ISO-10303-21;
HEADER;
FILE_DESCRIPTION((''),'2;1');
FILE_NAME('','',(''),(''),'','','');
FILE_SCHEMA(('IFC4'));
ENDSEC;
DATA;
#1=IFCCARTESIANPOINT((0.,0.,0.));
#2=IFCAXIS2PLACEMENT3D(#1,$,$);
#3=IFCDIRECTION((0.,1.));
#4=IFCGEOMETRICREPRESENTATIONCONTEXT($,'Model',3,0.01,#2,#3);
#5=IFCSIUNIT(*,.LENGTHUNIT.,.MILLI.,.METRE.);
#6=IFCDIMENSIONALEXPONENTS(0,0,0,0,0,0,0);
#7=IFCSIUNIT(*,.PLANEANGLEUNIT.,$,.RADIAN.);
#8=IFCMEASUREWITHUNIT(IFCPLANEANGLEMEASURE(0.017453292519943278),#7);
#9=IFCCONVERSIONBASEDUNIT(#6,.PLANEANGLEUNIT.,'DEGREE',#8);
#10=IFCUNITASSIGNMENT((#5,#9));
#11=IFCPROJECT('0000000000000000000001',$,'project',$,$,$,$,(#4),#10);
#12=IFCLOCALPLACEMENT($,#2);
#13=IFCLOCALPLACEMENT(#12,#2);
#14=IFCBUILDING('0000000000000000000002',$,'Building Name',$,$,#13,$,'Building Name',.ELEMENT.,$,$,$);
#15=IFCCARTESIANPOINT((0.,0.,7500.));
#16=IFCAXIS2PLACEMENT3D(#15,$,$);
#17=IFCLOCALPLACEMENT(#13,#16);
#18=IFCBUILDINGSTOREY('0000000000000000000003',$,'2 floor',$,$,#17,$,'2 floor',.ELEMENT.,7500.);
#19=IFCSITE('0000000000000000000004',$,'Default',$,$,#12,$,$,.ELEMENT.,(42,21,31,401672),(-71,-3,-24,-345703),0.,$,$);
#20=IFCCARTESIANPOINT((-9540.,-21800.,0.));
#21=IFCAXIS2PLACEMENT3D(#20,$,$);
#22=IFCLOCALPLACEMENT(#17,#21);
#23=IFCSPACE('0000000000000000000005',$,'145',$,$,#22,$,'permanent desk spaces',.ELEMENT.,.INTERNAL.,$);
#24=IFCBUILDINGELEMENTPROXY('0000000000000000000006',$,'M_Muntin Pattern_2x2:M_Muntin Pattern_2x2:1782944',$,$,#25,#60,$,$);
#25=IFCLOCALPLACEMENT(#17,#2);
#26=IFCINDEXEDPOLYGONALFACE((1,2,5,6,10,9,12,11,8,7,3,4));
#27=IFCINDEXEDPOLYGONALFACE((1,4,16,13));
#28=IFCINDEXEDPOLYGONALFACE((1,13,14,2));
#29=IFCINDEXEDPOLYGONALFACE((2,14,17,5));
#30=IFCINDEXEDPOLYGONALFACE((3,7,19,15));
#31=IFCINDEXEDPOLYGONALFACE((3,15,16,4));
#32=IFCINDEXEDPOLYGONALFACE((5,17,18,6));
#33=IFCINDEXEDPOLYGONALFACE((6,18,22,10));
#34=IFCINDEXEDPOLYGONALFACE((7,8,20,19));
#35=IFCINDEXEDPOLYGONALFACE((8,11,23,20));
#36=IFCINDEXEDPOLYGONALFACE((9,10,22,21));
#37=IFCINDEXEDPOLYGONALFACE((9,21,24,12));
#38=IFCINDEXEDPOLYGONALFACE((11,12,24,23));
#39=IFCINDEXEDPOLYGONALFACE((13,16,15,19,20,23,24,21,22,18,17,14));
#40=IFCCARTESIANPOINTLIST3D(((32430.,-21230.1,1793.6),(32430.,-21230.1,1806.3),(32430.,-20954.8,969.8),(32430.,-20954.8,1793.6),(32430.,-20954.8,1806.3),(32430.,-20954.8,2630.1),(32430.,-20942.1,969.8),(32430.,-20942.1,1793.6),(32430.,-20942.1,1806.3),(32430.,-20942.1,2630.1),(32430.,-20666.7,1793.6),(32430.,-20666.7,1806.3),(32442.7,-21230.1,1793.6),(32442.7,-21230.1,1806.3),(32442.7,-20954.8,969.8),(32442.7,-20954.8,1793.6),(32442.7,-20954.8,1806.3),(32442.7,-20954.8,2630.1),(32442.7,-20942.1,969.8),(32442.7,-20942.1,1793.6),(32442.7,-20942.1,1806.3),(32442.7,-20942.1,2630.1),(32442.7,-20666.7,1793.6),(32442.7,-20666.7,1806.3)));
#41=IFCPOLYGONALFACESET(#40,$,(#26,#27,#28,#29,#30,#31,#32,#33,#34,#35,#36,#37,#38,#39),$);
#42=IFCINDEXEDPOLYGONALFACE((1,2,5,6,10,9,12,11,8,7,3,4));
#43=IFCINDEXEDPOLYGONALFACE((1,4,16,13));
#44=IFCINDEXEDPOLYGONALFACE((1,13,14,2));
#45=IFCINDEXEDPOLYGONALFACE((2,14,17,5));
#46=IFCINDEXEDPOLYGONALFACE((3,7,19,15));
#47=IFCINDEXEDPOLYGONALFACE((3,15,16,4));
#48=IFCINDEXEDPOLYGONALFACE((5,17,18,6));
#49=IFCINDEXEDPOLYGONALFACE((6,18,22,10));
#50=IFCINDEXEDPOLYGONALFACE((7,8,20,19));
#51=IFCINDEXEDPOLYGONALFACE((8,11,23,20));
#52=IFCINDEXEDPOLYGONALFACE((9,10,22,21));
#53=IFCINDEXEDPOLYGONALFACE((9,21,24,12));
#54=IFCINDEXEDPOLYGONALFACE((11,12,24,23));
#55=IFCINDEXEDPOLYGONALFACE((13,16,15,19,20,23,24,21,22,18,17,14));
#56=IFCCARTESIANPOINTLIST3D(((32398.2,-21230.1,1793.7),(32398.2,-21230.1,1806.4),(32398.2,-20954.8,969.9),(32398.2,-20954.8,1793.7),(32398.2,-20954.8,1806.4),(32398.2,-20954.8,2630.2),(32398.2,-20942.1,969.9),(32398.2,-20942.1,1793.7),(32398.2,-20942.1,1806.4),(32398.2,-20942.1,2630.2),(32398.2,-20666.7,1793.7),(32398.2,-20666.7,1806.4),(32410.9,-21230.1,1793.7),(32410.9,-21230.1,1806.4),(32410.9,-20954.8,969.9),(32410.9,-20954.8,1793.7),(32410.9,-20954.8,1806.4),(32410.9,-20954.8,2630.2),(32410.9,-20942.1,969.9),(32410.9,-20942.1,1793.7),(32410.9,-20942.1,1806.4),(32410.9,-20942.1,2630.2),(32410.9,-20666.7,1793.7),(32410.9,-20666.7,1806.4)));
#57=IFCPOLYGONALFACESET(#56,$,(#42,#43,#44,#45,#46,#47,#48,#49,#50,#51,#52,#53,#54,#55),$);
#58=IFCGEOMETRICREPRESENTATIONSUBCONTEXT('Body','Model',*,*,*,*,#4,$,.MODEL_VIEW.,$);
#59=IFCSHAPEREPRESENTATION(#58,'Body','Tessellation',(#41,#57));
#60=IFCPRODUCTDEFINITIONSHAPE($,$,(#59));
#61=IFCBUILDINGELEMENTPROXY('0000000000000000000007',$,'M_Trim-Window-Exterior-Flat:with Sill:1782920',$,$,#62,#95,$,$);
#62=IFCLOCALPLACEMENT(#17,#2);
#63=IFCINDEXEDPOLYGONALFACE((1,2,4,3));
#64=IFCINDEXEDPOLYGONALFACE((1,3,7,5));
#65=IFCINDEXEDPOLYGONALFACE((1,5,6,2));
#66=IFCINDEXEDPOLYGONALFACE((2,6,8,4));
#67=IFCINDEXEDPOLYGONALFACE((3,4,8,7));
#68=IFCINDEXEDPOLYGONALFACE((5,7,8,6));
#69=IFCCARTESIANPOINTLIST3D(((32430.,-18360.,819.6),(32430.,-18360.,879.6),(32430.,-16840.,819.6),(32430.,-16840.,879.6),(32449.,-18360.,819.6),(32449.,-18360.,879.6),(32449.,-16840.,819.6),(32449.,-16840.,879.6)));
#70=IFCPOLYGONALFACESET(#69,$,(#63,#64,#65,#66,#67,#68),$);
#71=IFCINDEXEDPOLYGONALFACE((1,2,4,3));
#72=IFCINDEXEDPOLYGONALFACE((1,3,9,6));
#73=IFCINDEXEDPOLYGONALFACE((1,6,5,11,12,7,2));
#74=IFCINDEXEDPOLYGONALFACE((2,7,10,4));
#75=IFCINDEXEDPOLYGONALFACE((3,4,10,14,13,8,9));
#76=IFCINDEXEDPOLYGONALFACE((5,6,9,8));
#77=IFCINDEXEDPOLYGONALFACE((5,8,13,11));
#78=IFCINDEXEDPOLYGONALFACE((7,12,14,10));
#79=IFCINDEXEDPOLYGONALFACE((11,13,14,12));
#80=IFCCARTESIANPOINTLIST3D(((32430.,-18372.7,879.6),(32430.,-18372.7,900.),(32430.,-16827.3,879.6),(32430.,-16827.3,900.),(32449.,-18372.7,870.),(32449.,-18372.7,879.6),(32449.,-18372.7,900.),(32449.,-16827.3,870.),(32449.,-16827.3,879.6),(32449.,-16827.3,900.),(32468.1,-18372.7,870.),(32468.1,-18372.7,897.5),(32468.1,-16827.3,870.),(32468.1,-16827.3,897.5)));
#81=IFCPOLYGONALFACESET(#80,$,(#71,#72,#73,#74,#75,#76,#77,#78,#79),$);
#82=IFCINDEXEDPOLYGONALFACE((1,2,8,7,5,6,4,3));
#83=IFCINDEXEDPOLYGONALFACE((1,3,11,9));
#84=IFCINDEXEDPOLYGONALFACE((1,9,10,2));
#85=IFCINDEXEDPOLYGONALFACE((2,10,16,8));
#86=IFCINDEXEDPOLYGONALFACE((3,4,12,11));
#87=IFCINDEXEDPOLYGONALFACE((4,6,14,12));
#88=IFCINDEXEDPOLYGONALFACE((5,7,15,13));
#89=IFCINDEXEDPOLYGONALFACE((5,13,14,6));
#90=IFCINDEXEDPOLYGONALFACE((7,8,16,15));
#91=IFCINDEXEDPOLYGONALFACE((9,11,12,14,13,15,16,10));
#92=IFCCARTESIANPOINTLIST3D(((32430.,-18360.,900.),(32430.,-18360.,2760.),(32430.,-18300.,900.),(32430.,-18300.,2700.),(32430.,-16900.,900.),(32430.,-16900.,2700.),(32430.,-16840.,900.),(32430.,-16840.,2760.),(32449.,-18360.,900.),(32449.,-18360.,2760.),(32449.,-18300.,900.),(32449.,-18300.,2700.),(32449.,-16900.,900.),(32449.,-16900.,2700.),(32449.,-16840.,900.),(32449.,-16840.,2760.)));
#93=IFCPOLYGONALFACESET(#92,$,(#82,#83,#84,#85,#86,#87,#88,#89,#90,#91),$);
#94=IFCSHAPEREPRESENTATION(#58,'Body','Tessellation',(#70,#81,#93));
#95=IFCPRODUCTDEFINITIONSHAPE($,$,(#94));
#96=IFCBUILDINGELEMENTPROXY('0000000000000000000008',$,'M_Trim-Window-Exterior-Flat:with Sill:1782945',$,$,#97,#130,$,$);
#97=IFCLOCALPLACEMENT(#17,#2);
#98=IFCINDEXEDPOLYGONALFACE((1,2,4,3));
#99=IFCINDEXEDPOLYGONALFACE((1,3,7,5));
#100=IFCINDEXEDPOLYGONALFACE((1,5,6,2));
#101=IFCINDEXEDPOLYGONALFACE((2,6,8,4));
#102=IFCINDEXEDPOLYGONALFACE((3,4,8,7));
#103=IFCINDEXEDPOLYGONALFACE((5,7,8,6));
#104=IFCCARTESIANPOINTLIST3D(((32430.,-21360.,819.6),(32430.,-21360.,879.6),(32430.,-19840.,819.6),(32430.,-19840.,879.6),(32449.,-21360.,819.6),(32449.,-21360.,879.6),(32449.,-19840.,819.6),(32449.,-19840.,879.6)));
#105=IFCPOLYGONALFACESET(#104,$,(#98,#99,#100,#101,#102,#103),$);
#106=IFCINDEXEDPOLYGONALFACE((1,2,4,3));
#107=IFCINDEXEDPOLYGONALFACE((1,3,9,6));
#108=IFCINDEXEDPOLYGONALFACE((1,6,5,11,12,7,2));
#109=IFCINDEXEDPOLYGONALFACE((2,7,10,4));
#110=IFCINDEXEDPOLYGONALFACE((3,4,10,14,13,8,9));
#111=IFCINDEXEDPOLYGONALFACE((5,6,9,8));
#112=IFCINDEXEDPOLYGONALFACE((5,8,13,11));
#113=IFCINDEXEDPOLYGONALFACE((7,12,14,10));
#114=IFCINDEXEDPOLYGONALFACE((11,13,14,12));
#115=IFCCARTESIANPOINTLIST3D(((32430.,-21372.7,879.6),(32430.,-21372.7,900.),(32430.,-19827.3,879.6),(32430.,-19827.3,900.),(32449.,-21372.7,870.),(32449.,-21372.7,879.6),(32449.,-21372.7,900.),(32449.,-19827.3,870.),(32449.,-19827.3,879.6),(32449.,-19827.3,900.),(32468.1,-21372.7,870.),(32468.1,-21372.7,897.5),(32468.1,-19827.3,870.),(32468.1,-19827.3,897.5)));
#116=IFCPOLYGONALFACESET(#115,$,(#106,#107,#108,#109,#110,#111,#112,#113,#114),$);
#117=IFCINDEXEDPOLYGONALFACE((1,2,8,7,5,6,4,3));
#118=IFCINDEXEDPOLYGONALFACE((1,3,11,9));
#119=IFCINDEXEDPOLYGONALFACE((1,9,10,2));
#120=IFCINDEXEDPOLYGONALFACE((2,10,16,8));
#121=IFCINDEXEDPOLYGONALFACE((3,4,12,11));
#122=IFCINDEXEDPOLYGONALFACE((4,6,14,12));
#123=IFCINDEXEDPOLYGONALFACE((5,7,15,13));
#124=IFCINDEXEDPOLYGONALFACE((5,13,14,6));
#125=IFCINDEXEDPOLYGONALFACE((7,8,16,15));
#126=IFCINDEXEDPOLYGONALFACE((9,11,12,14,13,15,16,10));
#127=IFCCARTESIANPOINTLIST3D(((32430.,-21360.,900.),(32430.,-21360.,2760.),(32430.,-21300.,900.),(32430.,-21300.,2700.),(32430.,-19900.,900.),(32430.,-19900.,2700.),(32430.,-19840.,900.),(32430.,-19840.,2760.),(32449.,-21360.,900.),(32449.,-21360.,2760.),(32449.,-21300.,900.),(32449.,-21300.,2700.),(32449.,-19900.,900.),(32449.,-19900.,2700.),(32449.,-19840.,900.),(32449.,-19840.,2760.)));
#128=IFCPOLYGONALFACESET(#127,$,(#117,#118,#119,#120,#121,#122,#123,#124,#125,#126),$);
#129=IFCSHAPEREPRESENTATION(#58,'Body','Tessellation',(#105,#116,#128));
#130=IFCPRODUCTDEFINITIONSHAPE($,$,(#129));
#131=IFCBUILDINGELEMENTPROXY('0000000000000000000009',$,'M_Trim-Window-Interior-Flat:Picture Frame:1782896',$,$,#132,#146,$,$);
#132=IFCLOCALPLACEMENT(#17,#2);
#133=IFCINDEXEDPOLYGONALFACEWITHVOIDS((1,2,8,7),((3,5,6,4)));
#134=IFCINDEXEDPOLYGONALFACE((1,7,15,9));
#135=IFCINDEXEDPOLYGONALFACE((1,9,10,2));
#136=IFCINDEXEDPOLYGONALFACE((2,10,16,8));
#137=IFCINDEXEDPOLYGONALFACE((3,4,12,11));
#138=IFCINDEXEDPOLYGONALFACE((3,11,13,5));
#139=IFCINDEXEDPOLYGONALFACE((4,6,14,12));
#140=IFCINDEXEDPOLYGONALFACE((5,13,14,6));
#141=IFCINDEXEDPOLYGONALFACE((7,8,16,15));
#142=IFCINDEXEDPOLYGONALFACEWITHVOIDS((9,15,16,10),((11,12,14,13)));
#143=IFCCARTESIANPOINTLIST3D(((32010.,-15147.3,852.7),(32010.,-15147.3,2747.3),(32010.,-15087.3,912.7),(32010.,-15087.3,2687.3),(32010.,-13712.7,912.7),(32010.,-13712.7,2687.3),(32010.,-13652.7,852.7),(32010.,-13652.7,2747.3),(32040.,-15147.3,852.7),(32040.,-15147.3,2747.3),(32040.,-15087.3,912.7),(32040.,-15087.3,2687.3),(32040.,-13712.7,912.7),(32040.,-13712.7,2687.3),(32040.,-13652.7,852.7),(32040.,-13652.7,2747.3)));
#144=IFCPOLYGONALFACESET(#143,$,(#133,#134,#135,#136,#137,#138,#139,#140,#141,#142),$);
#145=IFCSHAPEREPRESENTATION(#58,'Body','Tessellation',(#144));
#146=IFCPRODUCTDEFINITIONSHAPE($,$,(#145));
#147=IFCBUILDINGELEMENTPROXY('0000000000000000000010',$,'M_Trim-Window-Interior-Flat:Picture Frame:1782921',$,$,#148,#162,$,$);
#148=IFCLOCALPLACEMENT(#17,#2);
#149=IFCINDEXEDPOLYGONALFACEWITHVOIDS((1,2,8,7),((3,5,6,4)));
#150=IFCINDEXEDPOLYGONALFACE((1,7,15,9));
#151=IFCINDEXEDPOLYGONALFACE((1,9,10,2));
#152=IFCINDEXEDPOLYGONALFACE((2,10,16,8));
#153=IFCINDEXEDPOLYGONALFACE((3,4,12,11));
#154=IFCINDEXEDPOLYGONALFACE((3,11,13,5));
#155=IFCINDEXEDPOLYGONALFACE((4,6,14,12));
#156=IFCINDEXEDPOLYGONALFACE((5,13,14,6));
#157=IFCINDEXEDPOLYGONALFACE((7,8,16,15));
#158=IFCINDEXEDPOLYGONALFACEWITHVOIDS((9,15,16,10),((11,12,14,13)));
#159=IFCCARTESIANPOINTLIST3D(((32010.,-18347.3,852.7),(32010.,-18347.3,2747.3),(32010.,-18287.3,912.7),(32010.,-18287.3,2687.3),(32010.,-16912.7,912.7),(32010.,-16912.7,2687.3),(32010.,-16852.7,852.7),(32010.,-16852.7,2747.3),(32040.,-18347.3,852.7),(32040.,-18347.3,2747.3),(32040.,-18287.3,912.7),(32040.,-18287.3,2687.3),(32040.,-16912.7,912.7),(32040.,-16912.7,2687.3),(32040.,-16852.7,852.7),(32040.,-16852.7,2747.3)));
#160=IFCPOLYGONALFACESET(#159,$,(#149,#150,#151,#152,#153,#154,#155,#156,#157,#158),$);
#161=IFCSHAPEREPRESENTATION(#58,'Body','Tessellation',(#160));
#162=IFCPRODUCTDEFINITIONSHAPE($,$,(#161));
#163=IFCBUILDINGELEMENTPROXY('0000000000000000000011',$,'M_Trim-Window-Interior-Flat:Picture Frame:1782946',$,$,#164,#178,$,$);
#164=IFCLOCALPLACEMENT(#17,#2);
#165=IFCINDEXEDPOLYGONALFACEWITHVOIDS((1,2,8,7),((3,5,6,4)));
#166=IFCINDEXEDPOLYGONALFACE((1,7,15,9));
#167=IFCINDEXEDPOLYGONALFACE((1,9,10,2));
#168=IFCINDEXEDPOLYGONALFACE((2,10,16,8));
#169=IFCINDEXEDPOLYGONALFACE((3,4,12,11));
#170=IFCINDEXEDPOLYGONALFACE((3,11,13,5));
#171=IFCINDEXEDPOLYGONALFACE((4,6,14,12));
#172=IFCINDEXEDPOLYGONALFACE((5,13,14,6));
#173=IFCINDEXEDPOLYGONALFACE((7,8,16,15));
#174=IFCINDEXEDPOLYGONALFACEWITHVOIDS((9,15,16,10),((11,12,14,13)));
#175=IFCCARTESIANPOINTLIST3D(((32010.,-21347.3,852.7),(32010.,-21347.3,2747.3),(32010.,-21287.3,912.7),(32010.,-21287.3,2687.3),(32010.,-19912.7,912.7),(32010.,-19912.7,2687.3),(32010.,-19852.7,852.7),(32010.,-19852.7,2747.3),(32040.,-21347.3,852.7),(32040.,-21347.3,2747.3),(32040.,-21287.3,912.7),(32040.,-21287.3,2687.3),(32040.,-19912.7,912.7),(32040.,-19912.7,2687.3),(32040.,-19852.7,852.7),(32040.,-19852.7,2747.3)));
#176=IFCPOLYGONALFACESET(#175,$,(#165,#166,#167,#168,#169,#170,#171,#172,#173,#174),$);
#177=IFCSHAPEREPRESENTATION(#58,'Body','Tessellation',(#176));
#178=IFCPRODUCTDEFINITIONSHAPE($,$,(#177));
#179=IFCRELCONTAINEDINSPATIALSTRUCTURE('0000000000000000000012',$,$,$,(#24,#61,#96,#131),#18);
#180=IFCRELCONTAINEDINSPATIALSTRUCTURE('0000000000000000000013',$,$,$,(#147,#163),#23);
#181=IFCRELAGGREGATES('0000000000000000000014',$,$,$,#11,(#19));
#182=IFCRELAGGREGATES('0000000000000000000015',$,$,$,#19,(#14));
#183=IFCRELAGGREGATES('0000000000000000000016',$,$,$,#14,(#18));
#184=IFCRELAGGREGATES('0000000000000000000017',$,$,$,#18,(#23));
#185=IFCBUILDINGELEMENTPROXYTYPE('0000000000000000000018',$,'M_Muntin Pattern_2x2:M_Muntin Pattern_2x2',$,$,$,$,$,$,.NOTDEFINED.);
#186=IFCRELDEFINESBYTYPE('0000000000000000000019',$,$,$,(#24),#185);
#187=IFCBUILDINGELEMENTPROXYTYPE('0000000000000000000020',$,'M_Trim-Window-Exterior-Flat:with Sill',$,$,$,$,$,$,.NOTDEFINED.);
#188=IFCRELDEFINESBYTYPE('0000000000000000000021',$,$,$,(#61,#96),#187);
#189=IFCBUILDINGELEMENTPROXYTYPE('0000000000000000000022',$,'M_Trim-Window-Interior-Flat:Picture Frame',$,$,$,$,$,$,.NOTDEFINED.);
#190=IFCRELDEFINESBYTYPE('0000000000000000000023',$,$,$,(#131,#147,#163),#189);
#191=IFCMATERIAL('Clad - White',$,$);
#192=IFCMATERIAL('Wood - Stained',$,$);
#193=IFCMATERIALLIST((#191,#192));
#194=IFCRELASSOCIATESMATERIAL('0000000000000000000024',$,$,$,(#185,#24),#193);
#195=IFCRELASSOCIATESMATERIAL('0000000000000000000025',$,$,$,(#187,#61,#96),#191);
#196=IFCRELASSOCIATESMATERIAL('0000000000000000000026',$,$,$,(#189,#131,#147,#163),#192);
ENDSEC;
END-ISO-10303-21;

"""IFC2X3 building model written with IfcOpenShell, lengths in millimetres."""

from ifc_helpers import new_model, entity, si_unit, converted_unit, direction, frame, frame_2d, origin, place, context, subcontext, project, spatial, polyline, rectangle, outline, extrude, source, transform, mapped, material, material_list, type_object, type_shapes, element, save


model = new_model("IFC2X3")

# Units and contexts
model_context = context("Model", 3, precision=0.01, world=origin(), true_north=direction((0.0, 1.0)))
body_context = subcontext(model_context, "Body", "Model", "MODEL_VIEW")
ifc_project = project(units=[si_unit("LENGTHUNIT", "METRE", prefix="MILLI"), converted_unit("PLANEANGLEUNIT", "DEGREE", entity("IfcPlaneAngleMeasure", 0.017453292519943278), si_unit("PLANEANGLEUNIT", "RADIAN"), dimensions=[0, 0, 0, 0, 0, 0, 0])], contexts=[model_context])

# Site, building, storey
site_placement = place(None, origin())
site = spatial("IfcSite", under=ifc_project, at=site_placement, Name="Default", CompositionType="ELEMENT", RefLatitude=(42, 21, 31, 401672), RefLongitude=(-71, -3, -24, -345703), RefElevation=0.0)
building_placement = place(site_placement, origin())
building = spatial("IfcBuilding", under=site, at=building_placement, Name="Building Name", LongName="Building Name", CompositionType="ELEMENT")
storey_placement = place(building_placement, frame((0.0, 0.0, 7500.0)))
storey = spatial("IfcBuildingStorey", under=building, at=storey_placement, Name="2 floor", LongName="2 floor", CompositionType="ELEMENT", Elevation=7500.0)

# Building element proxies
ifc_material_1 = material(Name="Clad - White")
ifc_material_2 = material(Name="Wood - Stained")
ifc_material_list = material_list([ifc_material_1, ifc_material_2])
building_element_proxy_type_1 = type_object("IfcBuildingElementProxyType", Name="M_Muntin Pattern_2x2:M_Muntin Pattern_2x2", PredefinedType="NOTDEFINED", material=ifc_material_list)
shared_shape_1 = source(origin(), body_context, "Body", "SweptSolid", [
    extrude(outline(polyline([(6.4, -6.4), (830.1, -6.4), (830.1, 6.3), (6.4, 6.3), (6.4, 281.7), (-6.3, 281.7), (-6.3, 6.3), (-830.2, 6.3), (-830.2, -6.4), (-6.3, -6.4), (-6.3, -281.7), (6.4, -281.7), (6.4, -6.4)])), frame((0.0, -22.2, 830.1), z_axis=(0.0, 1.0, 0.0), x_axis=(0.0, 0.0, 1.0)), (0.0, 0.0, 1.0), 12.7),
    extrude(outline(polyline([(6.4, -6.4), (830.2, -6.4), (830.2, 6.3), (6.4, 6.3), (6.4, 281.7), (-6.3, 281.7), (-6.3, 6.3), (-830.2, 6.3), (-830.2, -6.4), (-6.3, -6.4), (-6.3, -281.7), (6.4, -281.7), (6.4, -6.4)])), frame((0.0, 9.5, 830.2), z_axis=(0.0, 1.0, 0.0), x_axis=(0.0, 0.0, 1.0)), (0.0, 0.0, 1.0), 12.7),
])
type_shapes(building_element_proxy_type_1, [shared_shape_1])
for number, where, z_axis, x_axis, name in (
    (1, (32420.5, -20948.4, 969.9), (0.0, 0.0, 1.0), (0.0, 1.0, 0.0), "M_Muntin Pattern_2x2:M_Muntin Pattern_2x2:1782944"),
):
    element("IfcBuildingElementProxy", number, at=place(storey_placement, frame(where, z_axis=z_axis, x_axis=x_axis)), inside=storey, type_object=building_element_proxy_type_1, material=ifc_material_list, Name=name, context=body_context, shape_type="MappedRepresentation", body=[
        mapped(shared_shape_1, transform((0.0, 0.0, 0.0), scale=1.0)),
    ])
building_element_proxy_type_2 = type_object("IfcBuildingElementProxyType", Name="M_Trim-Window-Exterior-Flat:with Sill", PredefinedType="NOTDEFINED", material=ifc_material_1)
shared_shape_2 = source(origin(), body_context, "Body", "SweptSolid", [
    extrude(rectangle(XDim=1520.0, YDim=60.0, at=frame_2d((0.0, 0.0), x_axis=(1.0, 0.0))), frame((0.0, -1850.4, 0.0), z_axis=(0.0, 0.0, 1.0), x_axis=(-1.0, 0.0, 0.0)), (0.0, 0.0, 1.0), 19.0),
    extrude(outline(polyline([(-19.0, -15.2), (0.0, -15.2), (0.0, -5.7), (19.0, -5.7), (19.0, 14.8), (0.0, 14.8), (-19.0, 12.3), (-19.0, -15.2)])), frame((-772.7, -1814.8, 19.0), z_axis=(1.0, 0.0, 0.0), x_axis=(0.0, 0.0, -1.0)), (0.0, 0.0, 1.0), 1545.4),
    extrude(outline(polyline([(-945.0, -760.0), (915.0, -760.0), (915.0, -700.0), (-885.0, -700.0), (-885.0, 700.0), (915.0, 700.0), (915.0, 760.0), (-945.0, 760.0), (-945.0, -760.0)])), frame((0.0, -885.0, 0.0), z_axis=(0.0, 0.0, 1.0), x_axis=(0.0, -1.0, 0.0)), (0.0, 0.0, 1.0), 19.0),
])
type_shapes(building_element_proxy_type_2, [shared_shape_2])
for number, where, z_axis, x_axis, name in (
    (2, (32430.0, -17600.0, 2700.0), (1.0, 0.0, 0.0), (0.0, 1.0, 0.0), "M_Trim-Window-Exterior-Flat:with Sill:1782920"),
    (3, (32430.0, -20600.0, 2700.0), (1.0, 0.0, 0.0), (0.0, 1.0, 0.0), "M_Trim-Window-Exterior-Flat:with Sill:1782945"),
):
    element("IfcBuildingElementProxy", number, at=place(storey_placement, frame(where, z_axis=z_axis, x_axis=x_axis)), inside=storey, type_object=building_element_proxy_type_2, material=ifc_material_1, Name=name, context=body_context, shape_type="MappedRepresentation", body=[
        mapped(shared_shape_2, transform((0.0, 0.0, 0.0), scale=1.0)),
    ])
building_element_proxy_type_3 = type_object("IfcBuildingElementProxyType", Name="M_Trim-Window-Interior-Flat:Picture Frame", PredefinedType="NOTDEFINED", material=ifc_material_2)
shared_shape_3 = source(origin(), body_context, "Body", "SweptSolid", [
    extrude(outline(polyline([(-747.3, -947.3), (747.3, -947.3), (747.3, 947.3), (-747.3, 947.3), (-747.3, -947.3)]), holes=[polyline([(-687.3, -887.3), (-687.3, 887.3), (687.3, 887.3), (687.3, -887.3), (-687.3, -887.3)])]), frame((0.0, -900.0, 0.0), z_axis=(0.0, 0.0, 1.0), x_axis=(-1.0, 0.0, 0.0)), (0.0, 0.0, 1.0), 30.0),
])
type_shapes(building_element_proxy_type_3, [shared_shape_3])
proxy_placement = place(storey_placement, frame((32040.0, -14400.0, 2700.0), z_axis=(-1.0, 0.0, 0.0), x_axis=(0.0, -1.0, 0.0)))
element("IfcBuildingElementProxy", 4, at=proxy_placement, inside=storey, type_object=building_element_proxy_type_3, material=ifc_material_2, Name="M_Trim-Window-Interior-Flat:Picture Frame:1782896", context=body_context, shape_type="MappedRepresentation", body=[
    mapped(shared_shape_3, transform((0.0, 0.0, 0.0), scale=1.0)),
])

# Shared definitions
space_placement = place(storey_placement, frame((-9540.0, -21800.0, 0.0)))
space = spatial("IfcSpace", under=storey, at=space_placement, Name="145", LongName="permanent desk spaces", CompositionType="ELEMENT", InteriorOrExteriorSpace="INTERNAL")

# Building element proxies
for number, where, z_axis, x_axis, name in (
    (5, (41580.0, 4200.0, 2700.0), (-1.0, 0.0, 0.0), (0.0, -1.0, 0.0), "M_Trim-Window-Interior-Flat:Picture Frame:1782921"),
    (6, (41580.0, 1200.0, 2700.0), (-1.0, 0.0, 0.0), (0.0, -1.0, 0.0), "M_Trim-Window-Interior-Flat:Picture Frame:1782946"),
):
    element("IfcBuildingElementProxy", number, at=place(space_placement, frame(where, z_axis=z_axis, x_axis=x_axis)), inside=space, type_object=building_element_proxy_type_3, material=ifc_material_2, Name=name, context=body_context, shape_type="MappedRepresentation", body=[
        mapped(shared_shape_3, transform((0.0, 0.0, 0.0), scale=1.0)),
    ])

save(model, "model.ifc")
